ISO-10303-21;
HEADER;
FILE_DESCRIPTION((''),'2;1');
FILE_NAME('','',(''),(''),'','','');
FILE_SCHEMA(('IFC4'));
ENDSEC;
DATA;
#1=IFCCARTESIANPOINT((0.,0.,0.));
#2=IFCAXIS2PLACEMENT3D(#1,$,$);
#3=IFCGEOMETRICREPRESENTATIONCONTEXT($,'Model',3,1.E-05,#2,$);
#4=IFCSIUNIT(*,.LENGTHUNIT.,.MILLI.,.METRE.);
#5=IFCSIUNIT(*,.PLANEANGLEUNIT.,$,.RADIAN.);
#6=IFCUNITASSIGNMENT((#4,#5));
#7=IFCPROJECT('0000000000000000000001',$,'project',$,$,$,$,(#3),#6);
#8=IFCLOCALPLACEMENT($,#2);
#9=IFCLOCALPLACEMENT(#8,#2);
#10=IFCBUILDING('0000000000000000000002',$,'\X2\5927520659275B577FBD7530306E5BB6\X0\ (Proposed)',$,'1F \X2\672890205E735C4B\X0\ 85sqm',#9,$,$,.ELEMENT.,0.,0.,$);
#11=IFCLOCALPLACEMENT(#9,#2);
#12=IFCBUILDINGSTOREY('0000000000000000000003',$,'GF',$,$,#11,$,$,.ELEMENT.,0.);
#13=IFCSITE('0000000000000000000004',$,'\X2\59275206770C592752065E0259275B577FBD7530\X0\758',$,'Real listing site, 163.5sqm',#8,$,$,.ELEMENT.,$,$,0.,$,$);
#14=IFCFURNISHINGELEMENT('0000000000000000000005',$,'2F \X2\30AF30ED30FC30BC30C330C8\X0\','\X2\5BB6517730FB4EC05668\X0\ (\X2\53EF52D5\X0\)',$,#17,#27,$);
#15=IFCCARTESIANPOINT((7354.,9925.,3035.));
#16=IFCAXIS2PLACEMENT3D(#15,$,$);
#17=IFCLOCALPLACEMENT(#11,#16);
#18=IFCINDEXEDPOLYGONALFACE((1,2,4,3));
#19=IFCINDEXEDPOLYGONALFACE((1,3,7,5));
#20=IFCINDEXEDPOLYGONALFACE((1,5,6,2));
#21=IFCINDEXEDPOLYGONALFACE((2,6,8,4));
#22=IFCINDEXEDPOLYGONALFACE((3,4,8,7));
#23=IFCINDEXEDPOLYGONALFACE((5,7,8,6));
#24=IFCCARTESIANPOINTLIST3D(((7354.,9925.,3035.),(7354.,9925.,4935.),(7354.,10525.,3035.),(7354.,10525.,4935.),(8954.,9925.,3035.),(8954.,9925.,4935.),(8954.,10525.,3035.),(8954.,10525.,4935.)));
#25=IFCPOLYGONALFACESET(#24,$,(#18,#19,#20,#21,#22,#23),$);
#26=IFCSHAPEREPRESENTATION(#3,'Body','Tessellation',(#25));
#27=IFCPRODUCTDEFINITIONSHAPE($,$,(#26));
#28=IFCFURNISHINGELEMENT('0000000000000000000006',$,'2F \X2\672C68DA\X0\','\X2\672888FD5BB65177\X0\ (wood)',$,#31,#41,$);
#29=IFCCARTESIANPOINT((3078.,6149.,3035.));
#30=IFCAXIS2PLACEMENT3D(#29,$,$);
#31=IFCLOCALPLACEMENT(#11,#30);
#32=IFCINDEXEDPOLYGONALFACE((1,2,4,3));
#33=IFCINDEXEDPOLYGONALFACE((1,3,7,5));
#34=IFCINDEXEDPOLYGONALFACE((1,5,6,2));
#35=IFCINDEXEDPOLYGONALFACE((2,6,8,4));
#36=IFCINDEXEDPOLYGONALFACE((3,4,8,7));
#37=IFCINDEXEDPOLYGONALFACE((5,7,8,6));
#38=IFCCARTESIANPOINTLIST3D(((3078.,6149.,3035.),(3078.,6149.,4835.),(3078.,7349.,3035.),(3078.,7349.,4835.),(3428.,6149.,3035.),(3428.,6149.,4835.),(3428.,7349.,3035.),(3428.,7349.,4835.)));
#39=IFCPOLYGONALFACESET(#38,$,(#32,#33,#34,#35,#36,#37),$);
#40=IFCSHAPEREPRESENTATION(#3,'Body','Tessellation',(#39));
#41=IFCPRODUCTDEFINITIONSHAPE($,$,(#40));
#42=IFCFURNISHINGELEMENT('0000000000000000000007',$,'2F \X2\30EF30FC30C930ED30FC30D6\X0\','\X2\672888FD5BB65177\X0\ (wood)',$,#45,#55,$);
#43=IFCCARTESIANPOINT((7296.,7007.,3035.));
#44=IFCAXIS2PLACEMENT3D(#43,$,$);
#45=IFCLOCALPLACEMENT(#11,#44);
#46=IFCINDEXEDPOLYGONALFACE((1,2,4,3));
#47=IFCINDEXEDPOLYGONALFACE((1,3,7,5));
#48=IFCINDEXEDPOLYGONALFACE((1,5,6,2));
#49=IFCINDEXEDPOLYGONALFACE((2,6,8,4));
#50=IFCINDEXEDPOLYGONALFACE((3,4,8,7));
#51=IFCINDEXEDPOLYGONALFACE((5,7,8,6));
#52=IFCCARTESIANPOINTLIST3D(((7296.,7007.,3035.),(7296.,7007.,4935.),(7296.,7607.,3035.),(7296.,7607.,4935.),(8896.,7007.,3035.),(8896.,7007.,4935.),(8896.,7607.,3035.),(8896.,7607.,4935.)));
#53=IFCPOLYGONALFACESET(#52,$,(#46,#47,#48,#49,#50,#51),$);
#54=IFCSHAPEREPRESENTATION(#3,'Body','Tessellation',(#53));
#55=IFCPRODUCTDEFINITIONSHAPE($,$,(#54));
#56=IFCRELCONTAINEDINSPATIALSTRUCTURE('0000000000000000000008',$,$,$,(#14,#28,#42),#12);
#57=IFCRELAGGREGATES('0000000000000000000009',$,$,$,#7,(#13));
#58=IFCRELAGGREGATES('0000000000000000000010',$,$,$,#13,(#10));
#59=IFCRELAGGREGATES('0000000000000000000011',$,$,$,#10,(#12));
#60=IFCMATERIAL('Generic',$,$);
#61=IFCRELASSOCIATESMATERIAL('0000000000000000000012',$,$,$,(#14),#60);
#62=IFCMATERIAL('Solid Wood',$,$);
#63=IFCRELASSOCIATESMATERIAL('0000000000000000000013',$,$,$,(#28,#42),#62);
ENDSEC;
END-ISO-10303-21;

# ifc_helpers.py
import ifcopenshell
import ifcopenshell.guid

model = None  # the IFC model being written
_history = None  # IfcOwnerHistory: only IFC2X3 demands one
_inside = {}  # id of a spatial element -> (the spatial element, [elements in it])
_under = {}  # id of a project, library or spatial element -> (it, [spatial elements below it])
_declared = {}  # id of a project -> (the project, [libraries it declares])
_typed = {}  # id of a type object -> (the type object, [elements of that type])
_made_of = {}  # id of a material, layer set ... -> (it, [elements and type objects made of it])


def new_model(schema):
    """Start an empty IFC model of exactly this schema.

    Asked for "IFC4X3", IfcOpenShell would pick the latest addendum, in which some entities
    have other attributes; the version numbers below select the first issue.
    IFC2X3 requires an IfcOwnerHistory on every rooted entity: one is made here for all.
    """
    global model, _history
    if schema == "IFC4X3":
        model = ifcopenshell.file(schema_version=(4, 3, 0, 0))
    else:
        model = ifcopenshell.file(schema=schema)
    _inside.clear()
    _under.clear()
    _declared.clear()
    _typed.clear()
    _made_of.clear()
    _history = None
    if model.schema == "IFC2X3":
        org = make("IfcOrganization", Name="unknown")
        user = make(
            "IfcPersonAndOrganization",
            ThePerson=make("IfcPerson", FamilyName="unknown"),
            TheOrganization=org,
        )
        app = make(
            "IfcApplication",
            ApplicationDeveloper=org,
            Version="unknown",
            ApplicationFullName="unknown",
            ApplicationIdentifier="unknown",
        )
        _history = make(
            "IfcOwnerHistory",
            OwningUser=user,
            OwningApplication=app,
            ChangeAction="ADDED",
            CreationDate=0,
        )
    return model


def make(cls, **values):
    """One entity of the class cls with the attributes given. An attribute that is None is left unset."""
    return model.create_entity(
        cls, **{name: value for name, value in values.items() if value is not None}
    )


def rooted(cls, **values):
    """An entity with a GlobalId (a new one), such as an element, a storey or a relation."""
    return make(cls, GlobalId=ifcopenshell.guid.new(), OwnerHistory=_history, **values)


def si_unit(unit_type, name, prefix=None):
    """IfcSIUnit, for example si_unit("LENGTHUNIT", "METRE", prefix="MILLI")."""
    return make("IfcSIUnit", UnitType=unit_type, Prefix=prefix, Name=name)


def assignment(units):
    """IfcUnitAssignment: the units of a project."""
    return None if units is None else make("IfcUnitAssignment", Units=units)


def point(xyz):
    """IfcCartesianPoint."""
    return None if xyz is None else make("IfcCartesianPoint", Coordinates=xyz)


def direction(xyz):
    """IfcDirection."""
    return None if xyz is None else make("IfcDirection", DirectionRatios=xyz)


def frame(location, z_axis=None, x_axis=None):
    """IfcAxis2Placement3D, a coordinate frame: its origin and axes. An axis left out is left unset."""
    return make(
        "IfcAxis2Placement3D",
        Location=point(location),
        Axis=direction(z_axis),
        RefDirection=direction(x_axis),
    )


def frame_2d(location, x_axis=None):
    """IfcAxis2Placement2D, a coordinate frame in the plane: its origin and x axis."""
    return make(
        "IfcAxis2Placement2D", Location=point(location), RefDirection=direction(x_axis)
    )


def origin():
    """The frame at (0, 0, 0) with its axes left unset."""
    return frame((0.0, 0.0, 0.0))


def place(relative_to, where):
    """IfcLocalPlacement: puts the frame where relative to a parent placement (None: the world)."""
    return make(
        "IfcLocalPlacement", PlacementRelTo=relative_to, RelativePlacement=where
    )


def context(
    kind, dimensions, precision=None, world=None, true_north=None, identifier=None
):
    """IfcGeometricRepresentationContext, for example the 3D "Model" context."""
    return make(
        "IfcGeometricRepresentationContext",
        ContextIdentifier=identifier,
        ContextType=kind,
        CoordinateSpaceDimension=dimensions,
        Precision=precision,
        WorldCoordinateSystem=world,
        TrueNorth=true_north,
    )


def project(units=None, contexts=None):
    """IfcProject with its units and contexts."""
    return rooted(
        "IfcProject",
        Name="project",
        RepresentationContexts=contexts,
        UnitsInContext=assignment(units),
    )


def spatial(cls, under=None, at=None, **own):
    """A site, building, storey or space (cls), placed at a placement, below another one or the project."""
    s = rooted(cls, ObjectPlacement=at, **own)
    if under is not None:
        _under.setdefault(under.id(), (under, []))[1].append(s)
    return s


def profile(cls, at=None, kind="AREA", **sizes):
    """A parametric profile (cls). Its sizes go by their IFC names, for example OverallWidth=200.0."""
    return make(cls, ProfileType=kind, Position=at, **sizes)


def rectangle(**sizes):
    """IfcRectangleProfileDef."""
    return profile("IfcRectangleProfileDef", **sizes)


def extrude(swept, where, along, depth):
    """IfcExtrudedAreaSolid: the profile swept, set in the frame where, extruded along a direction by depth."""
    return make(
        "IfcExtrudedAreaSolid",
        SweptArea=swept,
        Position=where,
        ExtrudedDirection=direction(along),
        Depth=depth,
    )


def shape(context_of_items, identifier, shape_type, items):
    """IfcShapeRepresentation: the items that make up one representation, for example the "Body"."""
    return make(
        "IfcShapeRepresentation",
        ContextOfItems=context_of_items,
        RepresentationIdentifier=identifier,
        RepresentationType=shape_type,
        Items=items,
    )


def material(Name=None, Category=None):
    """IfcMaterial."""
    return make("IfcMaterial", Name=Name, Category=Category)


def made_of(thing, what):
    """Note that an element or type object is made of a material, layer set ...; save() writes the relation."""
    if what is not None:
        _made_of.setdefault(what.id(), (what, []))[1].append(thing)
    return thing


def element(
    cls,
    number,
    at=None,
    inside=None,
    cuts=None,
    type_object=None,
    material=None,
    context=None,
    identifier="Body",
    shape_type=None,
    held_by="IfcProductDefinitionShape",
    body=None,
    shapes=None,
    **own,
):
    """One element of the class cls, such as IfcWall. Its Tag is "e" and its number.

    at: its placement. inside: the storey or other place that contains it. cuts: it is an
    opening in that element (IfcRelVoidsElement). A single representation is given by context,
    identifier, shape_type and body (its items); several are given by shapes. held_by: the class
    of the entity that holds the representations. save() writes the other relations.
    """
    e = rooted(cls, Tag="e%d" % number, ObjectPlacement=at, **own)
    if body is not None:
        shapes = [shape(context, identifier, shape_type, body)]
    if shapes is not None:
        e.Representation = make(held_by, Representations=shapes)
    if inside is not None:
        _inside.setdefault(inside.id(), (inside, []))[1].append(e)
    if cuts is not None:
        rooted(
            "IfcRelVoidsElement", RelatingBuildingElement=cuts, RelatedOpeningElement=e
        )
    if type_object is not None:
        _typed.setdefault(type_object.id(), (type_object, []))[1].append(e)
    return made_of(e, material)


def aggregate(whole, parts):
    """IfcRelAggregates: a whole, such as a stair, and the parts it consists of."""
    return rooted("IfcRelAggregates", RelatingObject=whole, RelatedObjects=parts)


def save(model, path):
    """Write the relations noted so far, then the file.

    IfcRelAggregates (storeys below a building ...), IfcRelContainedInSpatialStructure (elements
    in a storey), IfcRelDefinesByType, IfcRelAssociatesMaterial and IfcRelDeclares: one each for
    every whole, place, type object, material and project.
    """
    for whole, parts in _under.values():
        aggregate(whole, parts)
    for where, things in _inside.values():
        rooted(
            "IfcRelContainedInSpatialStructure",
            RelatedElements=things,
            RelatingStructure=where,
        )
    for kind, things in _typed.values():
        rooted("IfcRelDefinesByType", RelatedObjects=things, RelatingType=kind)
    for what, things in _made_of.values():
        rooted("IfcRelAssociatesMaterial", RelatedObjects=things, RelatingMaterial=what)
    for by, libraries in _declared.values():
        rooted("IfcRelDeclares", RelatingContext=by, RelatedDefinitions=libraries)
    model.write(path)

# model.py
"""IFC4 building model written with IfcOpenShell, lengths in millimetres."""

from ifc_helpers import new_model, si_unit, frame, frame_2d, origin, place, context, project, spatial, rectangle, extrude, material, element, save


model = new_model("IFC4")

# Units and contexts
model_context = context("Model", 3, precision=1e-05, world=origin())
ifc_project = project(units=[si_unit("LENGTHUNIT", "METRE", prefix="MILLI"), si_unit("PLANEANGLEUNIT", "RADIAN")], contexts=[model_context])

# Site, building, storey
site_placement = place(None, origin())
site = spatial("IfcSite", under=ifc_project, at=site_placement, Name="大分県大分市大字羽田758", ObjectType="Real listing site, 163.5sqm", CompositionType="ELEMENT", RefElevation=0.0)
building_placement = place(site_placement, origin())
building = spatial("IfcBuilding", under=site, at=building_placement, Name="大分大字羽田の家 (Proposed)", ObjectType="1F 木造平屋 85sqm", CompositionType="ELEMENT", ElevationOfRefHeight=0.0, ElevationOfTerrain=0.0)
storey_placement = place(building_placement, origin())
storey = spatial("IfcBuildingStorey", under=building, at=storey_placement, Name="GF", CompositionType="ELEMENT", Elevation=0.0)

# Shared definitions
ifc_material_1 = material(Name="Solid Wood")

# Shared definitions
ifc_material_2 = material(Name="Generic")

# Furnishing elements
furnishing_1_placement = place(storey_placement, frame((7354.0, 9925.0, 3035.0)))
element("IfcFurnishingElement", 1, at=furnishing_1_placement, inside=storey, material=ifc_material_2, Name="2F クローゼット", Description="家具・什器 (可動)", context=model_context, shape_type="SweptSolid", body=[
    extrude(rectangle(XDim=1600.0, YDim=600.0, at=frame_2d((800.0, 300.0))), frame((7354.0, 9925.0, 3035.0)), (0.0, 0.0, 1.0), 1900.0),
])
furnishing_2_placement = place(storey_placement, frame((3078.0, 6149.0, 3035.0)))
element("IfcFurnishingElement", 2, at=furnishing_2_placement, inside=storey, material=ifc_material_1, Name="2F 本棚", Description="木製家具 (wood)", context=model_context, shape_type="SweptSolid", body=[
    extrude(rectangle(XDim=350.0, YDim=1200.0, at=frame_2d((175.0, 600.0))), frame((3078.0, 6149.0, 3035.0)), (0.0, 0.0, 1.0), 1800.0),
])
furnishing_3_placement = place(storey_placement, frame((7296.0, 7007.0, 3035.0)))
element("IfcFurnishingElement", 3, at=furnishing_3_placement, inside=storey, material=ifc_material_1, Name="2F ワードローブ", Description="木製家具 (wood)", context=model_context, shape_type="SweptSolid", body=[
    extrude(rectangle(XDim=1600.0, YDim=600.0, at=frame_2d((800.0, 300.0))), frame((7296.0, 7007.0, 3035.0)), (0.0, 0.0, 1.0), 1900.0),
])

save(model, "model.ifc")
